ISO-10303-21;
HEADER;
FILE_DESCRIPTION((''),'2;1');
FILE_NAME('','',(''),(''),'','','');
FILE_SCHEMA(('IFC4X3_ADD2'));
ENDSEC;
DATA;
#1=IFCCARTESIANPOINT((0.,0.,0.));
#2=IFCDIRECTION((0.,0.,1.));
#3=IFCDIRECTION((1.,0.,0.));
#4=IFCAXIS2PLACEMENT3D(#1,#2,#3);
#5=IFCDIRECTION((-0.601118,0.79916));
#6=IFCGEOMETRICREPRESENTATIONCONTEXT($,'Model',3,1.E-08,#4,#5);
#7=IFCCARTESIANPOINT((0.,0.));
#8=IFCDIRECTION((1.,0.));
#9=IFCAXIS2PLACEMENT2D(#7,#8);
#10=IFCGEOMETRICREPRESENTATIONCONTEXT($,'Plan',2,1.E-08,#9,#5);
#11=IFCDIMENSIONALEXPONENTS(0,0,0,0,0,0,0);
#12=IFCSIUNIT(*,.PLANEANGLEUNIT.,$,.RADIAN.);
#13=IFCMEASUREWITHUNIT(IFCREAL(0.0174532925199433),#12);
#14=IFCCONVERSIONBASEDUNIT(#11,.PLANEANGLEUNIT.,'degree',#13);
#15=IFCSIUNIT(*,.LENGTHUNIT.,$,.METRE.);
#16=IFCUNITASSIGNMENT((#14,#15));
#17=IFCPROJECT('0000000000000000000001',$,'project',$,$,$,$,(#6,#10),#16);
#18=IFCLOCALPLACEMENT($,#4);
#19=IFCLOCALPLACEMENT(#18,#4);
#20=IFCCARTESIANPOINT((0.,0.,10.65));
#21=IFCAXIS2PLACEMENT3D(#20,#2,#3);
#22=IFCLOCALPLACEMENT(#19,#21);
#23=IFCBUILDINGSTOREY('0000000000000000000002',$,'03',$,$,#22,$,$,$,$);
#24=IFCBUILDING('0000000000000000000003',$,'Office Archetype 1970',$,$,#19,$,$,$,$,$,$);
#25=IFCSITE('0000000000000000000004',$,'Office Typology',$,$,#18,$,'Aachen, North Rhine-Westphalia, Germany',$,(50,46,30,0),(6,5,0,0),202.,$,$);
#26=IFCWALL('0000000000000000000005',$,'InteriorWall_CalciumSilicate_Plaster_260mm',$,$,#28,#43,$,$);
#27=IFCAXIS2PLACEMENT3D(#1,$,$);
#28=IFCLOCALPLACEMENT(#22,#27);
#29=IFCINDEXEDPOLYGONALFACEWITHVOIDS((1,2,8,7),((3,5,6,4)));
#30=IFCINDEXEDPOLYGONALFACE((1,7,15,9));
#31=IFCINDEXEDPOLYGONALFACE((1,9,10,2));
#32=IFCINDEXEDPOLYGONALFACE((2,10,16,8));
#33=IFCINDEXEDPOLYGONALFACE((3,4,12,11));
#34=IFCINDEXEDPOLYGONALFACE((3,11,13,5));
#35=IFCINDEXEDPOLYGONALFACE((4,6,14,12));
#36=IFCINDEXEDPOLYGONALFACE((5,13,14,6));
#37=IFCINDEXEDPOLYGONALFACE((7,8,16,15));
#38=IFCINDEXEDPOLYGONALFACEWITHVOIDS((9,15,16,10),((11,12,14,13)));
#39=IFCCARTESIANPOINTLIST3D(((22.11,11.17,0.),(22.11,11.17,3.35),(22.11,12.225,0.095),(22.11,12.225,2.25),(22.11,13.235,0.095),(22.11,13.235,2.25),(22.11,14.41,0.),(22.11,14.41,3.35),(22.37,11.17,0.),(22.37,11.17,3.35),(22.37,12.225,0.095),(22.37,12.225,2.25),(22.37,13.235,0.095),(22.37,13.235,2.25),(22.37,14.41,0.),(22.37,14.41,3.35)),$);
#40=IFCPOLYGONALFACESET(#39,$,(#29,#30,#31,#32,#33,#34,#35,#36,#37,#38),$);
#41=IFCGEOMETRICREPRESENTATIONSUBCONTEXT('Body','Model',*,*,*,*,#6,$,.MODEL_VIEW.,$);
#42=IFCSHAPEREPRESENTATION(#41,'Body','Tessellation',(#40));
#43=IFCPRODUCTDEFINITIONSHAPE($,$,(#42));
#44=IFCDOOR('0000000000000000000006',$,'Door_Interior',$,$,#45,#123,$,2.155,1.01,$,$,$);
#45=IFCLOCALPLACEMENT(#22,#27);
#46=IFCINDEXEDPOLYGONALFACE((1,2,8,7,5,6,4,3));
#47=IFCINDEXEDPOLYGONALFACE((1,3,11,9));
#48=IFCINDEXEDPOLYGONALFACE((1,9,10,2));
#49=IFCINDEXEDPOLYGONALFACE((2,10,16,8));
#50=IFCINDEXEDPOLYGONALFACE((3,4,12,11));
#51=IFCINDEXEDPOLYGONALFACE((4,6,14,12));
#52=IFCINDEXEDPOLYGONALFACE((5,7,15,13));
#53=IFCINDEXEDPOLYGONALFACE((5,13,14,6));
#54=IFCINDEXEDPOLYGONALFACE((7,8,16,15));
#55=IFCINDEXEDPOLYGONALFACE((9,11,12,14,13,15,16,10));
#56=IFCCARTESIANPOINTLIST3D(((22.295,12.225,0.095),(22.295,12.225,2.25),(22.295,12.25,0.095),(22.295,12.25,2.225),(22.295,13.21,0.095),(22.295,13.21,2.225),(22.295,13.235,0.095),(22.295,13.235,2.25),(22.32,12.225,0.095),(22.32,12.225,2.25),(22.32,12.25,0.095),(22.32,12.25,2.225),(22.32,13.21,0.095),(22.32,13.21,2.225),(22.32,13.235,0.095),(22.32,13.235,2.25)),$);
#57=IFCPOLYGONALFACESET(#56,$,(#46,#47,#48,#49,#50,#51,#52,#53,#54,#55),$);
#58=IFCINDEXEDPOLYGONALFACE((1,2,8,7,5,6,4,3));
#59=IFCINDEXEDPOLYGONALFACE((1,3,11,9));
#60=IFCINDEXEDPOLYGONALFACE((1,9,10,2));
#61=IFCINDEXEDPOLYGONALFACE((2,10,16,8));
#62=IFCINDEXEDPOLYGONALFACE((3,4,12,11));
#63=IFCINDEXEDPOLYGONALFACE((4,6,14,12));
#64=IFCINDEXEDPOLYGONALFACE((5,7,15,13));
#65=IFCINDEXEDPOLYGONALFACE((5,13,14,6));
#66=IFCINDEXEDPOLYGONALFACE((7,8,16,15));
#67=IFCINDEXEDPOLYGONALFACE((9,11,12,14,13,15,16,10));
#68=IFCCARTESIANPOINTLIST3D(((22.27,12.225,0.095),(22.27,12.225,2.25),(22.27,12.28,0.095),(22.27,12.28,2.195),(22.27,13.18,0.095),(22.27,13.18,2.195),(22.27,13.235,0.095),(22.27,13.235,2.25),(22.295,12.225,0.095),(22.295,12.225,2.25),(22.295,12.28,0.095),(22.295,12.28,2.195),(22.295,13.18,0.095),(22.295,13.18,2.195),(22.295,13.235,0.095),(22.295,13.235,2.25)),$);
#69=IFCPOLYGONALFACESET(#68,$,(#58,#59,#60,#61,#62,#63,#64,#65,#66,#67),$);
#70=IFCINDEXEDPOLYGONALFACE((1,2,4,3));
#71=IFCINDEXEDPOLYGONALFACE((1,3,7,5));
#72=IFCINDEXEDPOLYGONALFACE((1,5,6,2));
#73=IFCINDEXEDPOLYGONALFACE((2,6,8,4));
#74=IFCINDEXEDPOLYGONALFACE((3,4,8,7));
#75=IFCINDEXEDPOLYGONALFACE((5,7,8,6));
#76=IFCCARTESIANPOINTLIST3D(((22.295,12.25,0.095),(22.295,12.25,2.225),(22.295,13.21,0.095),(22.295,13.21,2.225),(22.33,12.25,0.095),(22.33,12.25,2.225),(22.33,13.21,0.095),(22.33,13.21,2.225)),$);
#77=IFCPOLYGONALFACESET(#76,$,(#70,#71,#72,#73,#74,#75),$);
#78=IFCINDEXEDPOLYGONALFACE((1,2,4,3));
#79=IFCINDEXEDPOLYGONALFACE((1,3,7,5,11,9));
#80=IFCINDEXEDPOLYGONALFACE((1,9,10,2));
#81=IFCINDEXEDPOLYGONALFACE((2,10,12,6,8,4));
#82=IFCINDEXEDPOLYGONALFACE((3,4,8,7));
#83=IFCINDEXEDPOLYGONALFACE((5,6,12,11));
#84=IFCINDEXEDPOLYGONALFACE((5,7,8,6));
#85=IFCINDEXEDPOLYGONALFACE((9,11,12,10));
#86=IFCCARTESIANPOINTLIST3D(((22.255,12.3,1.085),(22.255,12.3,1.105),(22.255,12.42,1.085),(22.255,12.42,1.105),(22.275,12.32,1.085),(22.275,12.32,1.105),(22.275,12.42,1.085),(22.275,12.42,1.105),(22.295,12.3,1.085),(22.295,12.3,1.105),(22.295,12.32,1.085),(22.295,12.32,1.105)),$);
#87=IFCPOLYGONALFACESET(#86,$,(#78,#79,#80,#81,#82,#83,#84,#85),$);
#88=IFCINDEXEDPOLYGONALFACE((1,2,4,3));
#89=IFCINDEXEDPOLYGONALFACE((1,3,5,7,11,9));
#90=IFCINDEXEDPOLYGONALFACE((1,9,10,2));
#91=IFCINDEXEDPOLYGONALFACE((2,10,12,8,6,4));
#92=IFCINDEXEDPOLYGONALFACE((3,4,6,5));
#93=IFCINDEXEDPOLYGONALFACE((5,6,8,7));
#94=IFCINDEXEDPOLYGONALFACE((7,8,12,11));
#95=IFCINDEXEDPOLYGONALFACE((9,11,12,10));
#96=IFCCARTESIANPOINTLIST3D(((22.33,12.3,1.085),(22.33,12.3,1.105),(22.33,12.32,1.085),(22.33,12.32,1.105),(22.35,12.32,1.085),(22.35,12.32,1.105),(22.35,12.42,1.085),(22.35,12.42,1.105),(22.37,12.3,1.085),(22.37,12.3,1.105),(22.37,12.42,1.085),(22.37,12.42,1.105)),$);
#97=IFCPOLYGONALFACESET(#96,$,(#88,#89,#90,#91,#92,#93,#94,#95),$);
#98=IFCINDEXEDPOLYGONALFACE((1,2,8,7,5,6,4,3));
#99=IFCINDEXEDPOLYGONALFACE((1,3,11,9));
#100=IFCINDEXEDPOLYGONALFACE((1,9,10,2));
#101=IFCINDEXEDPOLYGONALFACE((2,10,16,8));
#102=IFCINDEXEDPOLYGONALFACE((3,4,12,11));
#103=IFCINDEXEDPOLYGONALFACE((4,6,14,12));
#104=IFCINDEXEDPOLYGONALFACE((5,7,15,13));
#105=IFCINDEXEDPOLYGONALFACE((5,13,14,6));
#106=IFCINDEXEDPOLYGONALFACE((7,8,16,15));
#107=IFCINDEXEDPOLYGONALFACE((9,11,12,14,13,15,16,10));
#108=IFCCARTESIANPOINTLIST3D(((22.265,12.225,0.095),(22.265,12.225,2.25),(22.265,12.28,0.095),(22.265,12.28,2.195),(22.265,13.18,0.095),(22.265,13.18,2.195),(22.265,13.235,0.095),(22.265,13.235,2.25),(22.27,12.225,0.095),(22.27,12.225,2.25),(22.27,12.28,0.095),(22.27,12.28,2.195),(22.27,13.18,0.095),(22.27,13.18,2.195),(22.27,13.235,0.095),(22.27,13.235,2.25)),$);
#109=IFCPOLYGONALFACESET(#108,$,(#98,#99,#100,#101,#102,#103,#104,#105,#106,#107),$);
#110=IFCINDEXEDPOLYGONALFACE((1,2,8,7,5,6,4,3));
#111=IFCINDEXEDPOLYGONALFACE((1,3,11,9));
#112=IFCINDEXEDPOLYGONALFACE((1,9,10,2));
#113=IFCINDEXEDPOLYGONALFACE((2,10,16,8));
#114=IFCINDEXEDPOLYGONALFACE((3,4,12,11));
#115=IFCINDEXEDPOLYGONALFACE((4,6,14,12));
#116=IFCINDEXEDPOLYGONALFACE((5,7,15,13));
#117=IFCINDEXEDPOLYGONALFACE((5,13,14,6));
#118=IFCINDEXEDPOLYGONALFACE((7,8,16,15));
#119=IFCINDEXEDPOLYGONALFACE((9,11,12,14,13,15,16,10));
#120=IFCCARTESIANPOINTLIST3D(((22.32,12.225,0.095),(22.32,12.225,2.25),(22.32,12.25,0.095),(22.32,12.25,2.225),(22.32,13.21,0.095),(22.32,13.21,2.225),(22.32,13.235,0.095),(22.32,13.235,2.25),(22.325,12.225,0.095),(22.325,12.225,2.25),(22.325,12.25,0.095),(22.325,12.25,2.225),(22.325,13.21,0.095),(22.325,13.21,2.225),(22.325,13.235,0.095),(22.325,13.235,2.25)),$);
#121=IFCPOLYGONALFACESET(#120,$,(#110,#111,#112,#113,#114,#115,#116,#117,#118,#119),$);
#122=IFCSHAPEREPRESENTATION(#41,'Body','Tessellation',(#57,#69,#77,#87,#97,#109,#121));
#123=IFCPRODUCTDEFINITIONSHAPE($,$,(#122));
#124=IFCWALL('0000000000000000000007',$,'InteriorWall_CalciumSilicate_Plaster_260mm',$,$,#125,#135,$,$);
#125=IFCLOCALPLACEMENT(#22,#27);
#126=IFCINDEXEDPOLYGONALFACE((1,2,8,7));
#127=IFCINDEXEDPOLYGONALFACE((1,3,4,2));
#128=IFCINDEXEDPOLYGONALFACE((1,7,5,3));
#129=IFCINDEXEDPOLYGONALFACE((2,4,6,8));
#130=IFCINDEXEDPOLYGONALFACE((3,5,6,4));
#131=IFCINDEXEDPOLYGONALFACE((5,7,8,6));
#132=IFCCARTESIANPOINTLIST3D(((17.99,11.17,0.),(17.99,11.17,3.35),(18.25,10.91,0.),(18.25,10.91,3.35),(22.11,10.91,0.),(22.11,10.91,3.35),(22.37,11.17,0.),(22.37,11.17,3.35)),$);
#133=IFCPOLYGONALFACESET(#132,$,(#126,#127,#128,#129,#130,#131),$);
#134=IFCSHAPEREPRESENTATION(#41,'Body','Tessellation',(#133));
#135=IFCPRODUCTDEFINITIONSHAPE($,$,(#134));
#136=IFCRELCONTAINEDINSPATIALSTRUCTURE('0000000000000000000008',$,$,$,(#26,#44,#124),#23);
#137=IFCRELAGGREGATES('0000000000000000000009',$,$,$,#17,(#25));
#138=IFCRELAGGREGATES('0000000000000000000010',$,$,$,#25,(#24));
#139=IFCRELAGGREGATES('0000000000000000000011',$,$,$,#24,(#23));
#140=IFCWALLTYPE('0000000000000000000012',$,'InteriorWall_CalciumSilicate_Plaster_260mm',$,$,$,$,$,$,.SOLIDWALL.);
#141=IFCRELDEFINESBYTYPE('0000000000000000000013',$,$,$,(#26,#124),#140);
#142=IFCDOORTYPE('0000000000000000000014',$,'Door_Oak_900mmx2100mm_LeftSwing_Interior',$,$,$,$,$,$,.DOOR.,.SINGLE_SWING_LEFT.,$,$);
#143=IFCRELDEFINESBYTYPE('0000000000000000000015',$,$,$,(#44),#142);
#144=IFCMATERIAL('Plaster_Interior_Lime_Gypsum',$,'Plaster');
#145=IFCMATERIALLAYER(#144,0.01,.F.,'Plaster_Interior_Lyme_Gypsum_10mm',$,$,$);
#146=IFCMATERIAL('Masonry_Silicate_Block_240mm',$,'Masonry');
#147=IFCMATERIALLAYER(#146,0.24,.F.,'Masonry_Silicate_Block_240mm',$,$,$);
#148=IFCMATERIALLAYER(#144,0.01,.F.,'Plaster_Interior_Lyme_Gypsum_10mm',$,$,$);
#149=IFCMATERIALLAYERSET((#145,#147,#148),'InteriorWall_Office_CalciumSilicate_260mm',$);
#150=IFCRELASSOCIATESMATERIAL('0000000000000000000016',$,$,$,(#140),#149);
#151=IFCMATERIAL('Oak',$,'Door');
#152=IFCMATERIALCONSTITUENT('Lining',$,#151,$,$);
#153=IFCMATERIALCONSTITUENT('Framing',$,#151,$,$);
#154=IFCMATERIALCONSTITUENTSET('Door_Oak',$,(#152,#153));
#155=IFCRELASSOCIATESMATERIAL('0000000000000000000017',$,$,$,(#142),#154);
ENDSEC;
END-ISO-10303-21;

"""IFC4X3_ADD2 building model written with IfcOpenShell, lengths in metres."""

from ifc_helpers import new_model, entity, si_unit, converted_unit, direction, frame, origin_with_axes, origin_2d_with_axis, place, context, subcontext, project, spatial, line, indexed_curve, outline, extrude, source, transform, mapped, material, layer, layer_set, constituent, constituent_set, type_object, type_shapes, element, fill, save


model = new_model("IFC4X3_ADD2")

# Units and contexts
model_context = context("Model", 3, precision=1e-08, world=origin_with_axes(), true_north=direction((-0.601118, 0.79916)))
plan_context = context("Plan", 2, precision=1e-08, world=origin_2d_with_axis(), true_north=direction((-0.601118, 0.79916)))
body_context = subcontext(model_context, "Body", "Model", "MODEL_VIEW")
ifc_project = project(units=[converted_unit("PLANEANGLEUNIT", "degree", entity("IfcReal", 0.0174532925199433), si_unit("PLANEANGLEUNIT", "RADIAN"), dimensions=[0, 0, 0, 0, 0, 0, 0]), si_unit("LENGTHUNIT", "METRE")], contexts=[model_context, plan_context])

# Site, building, storey
site_placement = place(None, origin_with_axes())
site = spatial("IfcSite", under=ifc_project, at=site_placement, Name="Office Typology", LongName="Aachen, North Rhine-Westphalia, Germany", RefLatitude=(50, 46, 30, 0), RefLongitude=(6, 5, 0, 0), RefElevation=202.0)
building_placement = place(site_placement, origin_with_axes())
building = spatial("IfcBuilding", under=site, at=building_placement, Name="Office Archetype 1970")
storey_placement = place(building_placement, frame((0.0, 0.0, 10.65), z_axis=(0.0, 0.0, 1.0), x_axis=(1.0, 0.0, 0.0)))
storey = spatial("IfcBuildingStorey", under=building, at=storey_placement, Name="03")

# Wall, opening, door
ifc_material_1 = material(Name="Plaster_Interior_Lime_Gypsum", Category="Plaster")
ifc_layer_1 = layer(ifc_material_1, 0.01, ventilated=False, Name="Plaster_Interior_Lyme_Gypsum_10mm")
ifc_material_2 = material(Name="Masonry_Silicate_Block_240mm", Category="Masonry")
ifc_layer_2 = layer(ifc_material_2, 0.24, ventilated=False, Name="Masonry_Silicate_Block_240mm")
ifc_layer_3 = layer(ifc_material_1, 0.01, ventilated=False, Name="Plaster_Interior_Lyme_Gypsum_10mm")
ifc_layer_set_1 = layer_set([ifc_layer_1, ifc_layer_2, ifc_layer_3], Name="InteriorWall_Office_CalciumSilicate_260mm")
wall_type_1 = type_object("IfcWallType", Name="InteriorWall_CalciumSilicate_Plaster_260mm", PredefinedType="SOLIDWALL", material=ifc_layer_set_1)
wall_1_placement = place(storey_placement, frame((22.37, 11.17, 0.0), z_axis=(0.0, 0.0, 1.0), x_axis=(0.0, 1.0, 0.0)))
wall_1 = element("IfcWall", 1, at=wall_1_placement, inside=storey, type_object=wall_type_1, Name="InteriorWall_CalciumSilicate_Plaster_260mm", context=body_context, shape_type="SweptSolid", body=[
    extrude(outline(indexed_curve([(3.24, 0.0), (3.24, 0.26), (0.0, 0.26), (0.0, 0.0), (3.24, 0.0)])), origin_with_axes(), (0.0, 0.0, 1.0), 3.35),
])
shared_shape_1 = source(origin_with_axes(), body_context, "Body", "SweptSolid", [
    extrude(outline(indexed_curve([(0.0, 0.0), (1.01, 0.0), (1.01, 2.155), (0.0, 2.155), (0.0, 0.0)])), frame((0.0, -0.16, 0.0), z_axis=(0.0, -1.0, 0.0), x_axis=(1.0, 0.0, 0.0)), (0.0, 0.0, -1.0), 0.261),
])
opening_1_placement = place(wall_1_placement, frame((2.065, 0.1, 0.095), z_axis=(0.0, 0.0, 1.0), x_axis=(-1.0, 0.0, 0.0)))
opening_1 = element("IfcOpeningElement", 2, at=opening_1_placement, cuts=wall_1, PredefinedType="OPENING", context=body_context, shape_type="MappedRepresentation", body=[
    mapped(shared_shape_1, transform((0.0, 0.0, 0.0), x_axis=(1.0, 0.0, 0.0), y_axis=(0.0, 1.0, 0.0), z_axis=(0.0, 0.0, 1.0), scale=1.0)),
])
ifc_material_3 = material(Name="Oak", Category="Door")
ifc_constituent_1 = constituent(ifc_material_3, Name="Lining")
ifc_constituent_2 = constituent(ifc_material_3, Name="Framing")
ifc_constituent_set_1 = constituent_set(constituents=[ifc_constituent_1, ifc_constituent_2], Name="Door_Oak")
door_type = type_object("IfcDoorType", Name="Door_Oak_900mmx2100mm_LeftSwing_Interior", OperationType="SINGLE_SWING_LEFT", PredefinedType="DOOR", material=ifc_constituent_set_1)
shared_shape_2 = source(origin_with_axes(), body_context, "Body", "SweptSolid", [
    extrude(outline(indexed_curve([(0.0, 0.0), (0.0, 2.155), (1.01, 2.155), (1.01, 0.0), (0.985, 0.0), (0.985, 2.13), (0.025, 2.13), (0.025, 0.0)], segments=[line(1, 2, 3, 4, 5, 6, 7, 8, 1)])), frame((0.0, 0.025, 0.0), z_axis=(0.0, -1.0, 0.0), x_axis=(1.0, 0.0, 0.0)), (0.0, 0.0, -1.0), 0.025),
    extrude(outline(indexed_curve([(0.0, 0.0), (0.0, 2.155), (1.01, 2.155), (1.01, 0.0), (0.955, 0.0), (0.955, 2.1), (0.055, 2.1), (0.055, 0.0)], segments=[line(1, 2, 3, 4, 5, 6, 7, 8, 1)])), frame((0.0, 0.0, 0.0), z_axis=(0.0, -1.0, 0.0), x_axis=(1.0, 0.0, 0.0)), (0.0, 0.0, -1.0), 0.025),
    extrude(outline(indexed_curve([(0.0, 0.0), (0.96, 0.0), (0.96, 0.035), (0.0, 0.035)], segments=[line(1, 2, 3, 4, 1)])), frame((0.025, 0.025, 0.0), z_axis=(0.0, 0.0, 1.0), x_axis=(1.0, 0.0, 0.0)), (0.0, 0.0, 1.0), 2.13),
    extrude(outline(indexed_curve([(0.0, 0.0), (0.0, -0.04), (-0.12, -0.04), (-0.12, -0.02), (-0.02, -0.02), (-0.02, 0.0)], segments=[line(1, 2, 3, 4, 5, 6, 1)])), frame((0.935, 0.025, 0.99), z_axis=(0.0, 0.0, 1.0), x_axis=(1.0, 0.0, 0.0)), (0.0, 0.0, 1.0), 0.02),
    extrude(outline(indexed_curve([(0.0, 0.0), (0.0, 0.04), (-0.12, 0.04), (-0.12, 0.02), (-0.02, 0.02), (-0.02, 0.0)], segments=[line(1, 2, 3, 4, 5, 6, 1)])), frame((0.935, 0.06, 0.99), z_axis=(0.0, 0.0, 1.0), x_axis=(1.0, 0.0, 0.0)), (0.0, 0.0, 1.0), 0.02),
    extrude(outline(indexed_curve([(0.0, 0.0), (0.0, 2.155), (1.01, 2.155), (1.01, 0.0), (0.955, 0.0), (0.955, 2.1), (0.055, 2.1), (0.055, 0.0)], segments=[line(1, 2, 3, 4, 5, 6, 7, 8, 1)])), frame((0.0, -0.005, 0.0), z_axis=(0.0, -1.0, 0.0), x_axis=(1.0, 0.0, 0.0)), (0.0, 0.0, -1.0), 0.005),
    extrude(outline(indexed_curve([(0.0, 0.0), (0.0, 2.155), (1.01, 2.155), (1.01, 0.0), (0.985, 0.0), (0.985, 2.13), (0.025, 2.13), (0.025, 0.0)], segments=[line(1, 2, 3, 4, 5, 6, 7, 8, 1)])), frame((0.0, 0.05, 0.0), z_axis=(0.0, -1.0, 0.0), x_axis=(1.0, 0.0, 0.0)), (0.0, 0.0, -1.0), 0.005),
])
type_shapes(door_type, [shared_shape_2])
door_placement = place(opening_1_placement, origin_with_axes())
door = element("IfcDoor", 3, at=door_placement, inside=storey, type_object=door_type, Name="Door_Interior", OverallHeight=2.155, OverallWidth=1.01, context=body_context, shape_type="MappedRepresentation", body=[
    mapped(shared_shape_2, transform((0.0, 0.0, 0.0), x_axis=(1.0, 0.0, 0.0), y_axis=(0.0, 1.0, 0.0), z_axis=(0.0, 0.0, 1.0), scale=1.0)),
])
fill(opening_1, door)

# Wall
wall_2_placement = place(storey_placement, frame((22.37, 11.17, 0.0), z_axis=(0.0, 0.0, 1.0), x_axis=(-1.0, 0.0, 0.0)))
element("IfcWall", 4, at=wall_2_placement, inside=storey, type_object=wall_type_1, Name="InteriorWall_CalciumSilicate_Plaster_260mm", context=body_context, shape_type="SweptSolid", body=[
    extrude(outline(indexed_curve([(0.0, 0.0), (0.26, 0.26), (4.12, 0.26), (4.38, 0.0)], segments=[line(1, 2, 3, 4, 1)])), origin_with_axes(), (0.0, 0.0, 1.0), 3.35),
])

save(model, "model.ifc")
